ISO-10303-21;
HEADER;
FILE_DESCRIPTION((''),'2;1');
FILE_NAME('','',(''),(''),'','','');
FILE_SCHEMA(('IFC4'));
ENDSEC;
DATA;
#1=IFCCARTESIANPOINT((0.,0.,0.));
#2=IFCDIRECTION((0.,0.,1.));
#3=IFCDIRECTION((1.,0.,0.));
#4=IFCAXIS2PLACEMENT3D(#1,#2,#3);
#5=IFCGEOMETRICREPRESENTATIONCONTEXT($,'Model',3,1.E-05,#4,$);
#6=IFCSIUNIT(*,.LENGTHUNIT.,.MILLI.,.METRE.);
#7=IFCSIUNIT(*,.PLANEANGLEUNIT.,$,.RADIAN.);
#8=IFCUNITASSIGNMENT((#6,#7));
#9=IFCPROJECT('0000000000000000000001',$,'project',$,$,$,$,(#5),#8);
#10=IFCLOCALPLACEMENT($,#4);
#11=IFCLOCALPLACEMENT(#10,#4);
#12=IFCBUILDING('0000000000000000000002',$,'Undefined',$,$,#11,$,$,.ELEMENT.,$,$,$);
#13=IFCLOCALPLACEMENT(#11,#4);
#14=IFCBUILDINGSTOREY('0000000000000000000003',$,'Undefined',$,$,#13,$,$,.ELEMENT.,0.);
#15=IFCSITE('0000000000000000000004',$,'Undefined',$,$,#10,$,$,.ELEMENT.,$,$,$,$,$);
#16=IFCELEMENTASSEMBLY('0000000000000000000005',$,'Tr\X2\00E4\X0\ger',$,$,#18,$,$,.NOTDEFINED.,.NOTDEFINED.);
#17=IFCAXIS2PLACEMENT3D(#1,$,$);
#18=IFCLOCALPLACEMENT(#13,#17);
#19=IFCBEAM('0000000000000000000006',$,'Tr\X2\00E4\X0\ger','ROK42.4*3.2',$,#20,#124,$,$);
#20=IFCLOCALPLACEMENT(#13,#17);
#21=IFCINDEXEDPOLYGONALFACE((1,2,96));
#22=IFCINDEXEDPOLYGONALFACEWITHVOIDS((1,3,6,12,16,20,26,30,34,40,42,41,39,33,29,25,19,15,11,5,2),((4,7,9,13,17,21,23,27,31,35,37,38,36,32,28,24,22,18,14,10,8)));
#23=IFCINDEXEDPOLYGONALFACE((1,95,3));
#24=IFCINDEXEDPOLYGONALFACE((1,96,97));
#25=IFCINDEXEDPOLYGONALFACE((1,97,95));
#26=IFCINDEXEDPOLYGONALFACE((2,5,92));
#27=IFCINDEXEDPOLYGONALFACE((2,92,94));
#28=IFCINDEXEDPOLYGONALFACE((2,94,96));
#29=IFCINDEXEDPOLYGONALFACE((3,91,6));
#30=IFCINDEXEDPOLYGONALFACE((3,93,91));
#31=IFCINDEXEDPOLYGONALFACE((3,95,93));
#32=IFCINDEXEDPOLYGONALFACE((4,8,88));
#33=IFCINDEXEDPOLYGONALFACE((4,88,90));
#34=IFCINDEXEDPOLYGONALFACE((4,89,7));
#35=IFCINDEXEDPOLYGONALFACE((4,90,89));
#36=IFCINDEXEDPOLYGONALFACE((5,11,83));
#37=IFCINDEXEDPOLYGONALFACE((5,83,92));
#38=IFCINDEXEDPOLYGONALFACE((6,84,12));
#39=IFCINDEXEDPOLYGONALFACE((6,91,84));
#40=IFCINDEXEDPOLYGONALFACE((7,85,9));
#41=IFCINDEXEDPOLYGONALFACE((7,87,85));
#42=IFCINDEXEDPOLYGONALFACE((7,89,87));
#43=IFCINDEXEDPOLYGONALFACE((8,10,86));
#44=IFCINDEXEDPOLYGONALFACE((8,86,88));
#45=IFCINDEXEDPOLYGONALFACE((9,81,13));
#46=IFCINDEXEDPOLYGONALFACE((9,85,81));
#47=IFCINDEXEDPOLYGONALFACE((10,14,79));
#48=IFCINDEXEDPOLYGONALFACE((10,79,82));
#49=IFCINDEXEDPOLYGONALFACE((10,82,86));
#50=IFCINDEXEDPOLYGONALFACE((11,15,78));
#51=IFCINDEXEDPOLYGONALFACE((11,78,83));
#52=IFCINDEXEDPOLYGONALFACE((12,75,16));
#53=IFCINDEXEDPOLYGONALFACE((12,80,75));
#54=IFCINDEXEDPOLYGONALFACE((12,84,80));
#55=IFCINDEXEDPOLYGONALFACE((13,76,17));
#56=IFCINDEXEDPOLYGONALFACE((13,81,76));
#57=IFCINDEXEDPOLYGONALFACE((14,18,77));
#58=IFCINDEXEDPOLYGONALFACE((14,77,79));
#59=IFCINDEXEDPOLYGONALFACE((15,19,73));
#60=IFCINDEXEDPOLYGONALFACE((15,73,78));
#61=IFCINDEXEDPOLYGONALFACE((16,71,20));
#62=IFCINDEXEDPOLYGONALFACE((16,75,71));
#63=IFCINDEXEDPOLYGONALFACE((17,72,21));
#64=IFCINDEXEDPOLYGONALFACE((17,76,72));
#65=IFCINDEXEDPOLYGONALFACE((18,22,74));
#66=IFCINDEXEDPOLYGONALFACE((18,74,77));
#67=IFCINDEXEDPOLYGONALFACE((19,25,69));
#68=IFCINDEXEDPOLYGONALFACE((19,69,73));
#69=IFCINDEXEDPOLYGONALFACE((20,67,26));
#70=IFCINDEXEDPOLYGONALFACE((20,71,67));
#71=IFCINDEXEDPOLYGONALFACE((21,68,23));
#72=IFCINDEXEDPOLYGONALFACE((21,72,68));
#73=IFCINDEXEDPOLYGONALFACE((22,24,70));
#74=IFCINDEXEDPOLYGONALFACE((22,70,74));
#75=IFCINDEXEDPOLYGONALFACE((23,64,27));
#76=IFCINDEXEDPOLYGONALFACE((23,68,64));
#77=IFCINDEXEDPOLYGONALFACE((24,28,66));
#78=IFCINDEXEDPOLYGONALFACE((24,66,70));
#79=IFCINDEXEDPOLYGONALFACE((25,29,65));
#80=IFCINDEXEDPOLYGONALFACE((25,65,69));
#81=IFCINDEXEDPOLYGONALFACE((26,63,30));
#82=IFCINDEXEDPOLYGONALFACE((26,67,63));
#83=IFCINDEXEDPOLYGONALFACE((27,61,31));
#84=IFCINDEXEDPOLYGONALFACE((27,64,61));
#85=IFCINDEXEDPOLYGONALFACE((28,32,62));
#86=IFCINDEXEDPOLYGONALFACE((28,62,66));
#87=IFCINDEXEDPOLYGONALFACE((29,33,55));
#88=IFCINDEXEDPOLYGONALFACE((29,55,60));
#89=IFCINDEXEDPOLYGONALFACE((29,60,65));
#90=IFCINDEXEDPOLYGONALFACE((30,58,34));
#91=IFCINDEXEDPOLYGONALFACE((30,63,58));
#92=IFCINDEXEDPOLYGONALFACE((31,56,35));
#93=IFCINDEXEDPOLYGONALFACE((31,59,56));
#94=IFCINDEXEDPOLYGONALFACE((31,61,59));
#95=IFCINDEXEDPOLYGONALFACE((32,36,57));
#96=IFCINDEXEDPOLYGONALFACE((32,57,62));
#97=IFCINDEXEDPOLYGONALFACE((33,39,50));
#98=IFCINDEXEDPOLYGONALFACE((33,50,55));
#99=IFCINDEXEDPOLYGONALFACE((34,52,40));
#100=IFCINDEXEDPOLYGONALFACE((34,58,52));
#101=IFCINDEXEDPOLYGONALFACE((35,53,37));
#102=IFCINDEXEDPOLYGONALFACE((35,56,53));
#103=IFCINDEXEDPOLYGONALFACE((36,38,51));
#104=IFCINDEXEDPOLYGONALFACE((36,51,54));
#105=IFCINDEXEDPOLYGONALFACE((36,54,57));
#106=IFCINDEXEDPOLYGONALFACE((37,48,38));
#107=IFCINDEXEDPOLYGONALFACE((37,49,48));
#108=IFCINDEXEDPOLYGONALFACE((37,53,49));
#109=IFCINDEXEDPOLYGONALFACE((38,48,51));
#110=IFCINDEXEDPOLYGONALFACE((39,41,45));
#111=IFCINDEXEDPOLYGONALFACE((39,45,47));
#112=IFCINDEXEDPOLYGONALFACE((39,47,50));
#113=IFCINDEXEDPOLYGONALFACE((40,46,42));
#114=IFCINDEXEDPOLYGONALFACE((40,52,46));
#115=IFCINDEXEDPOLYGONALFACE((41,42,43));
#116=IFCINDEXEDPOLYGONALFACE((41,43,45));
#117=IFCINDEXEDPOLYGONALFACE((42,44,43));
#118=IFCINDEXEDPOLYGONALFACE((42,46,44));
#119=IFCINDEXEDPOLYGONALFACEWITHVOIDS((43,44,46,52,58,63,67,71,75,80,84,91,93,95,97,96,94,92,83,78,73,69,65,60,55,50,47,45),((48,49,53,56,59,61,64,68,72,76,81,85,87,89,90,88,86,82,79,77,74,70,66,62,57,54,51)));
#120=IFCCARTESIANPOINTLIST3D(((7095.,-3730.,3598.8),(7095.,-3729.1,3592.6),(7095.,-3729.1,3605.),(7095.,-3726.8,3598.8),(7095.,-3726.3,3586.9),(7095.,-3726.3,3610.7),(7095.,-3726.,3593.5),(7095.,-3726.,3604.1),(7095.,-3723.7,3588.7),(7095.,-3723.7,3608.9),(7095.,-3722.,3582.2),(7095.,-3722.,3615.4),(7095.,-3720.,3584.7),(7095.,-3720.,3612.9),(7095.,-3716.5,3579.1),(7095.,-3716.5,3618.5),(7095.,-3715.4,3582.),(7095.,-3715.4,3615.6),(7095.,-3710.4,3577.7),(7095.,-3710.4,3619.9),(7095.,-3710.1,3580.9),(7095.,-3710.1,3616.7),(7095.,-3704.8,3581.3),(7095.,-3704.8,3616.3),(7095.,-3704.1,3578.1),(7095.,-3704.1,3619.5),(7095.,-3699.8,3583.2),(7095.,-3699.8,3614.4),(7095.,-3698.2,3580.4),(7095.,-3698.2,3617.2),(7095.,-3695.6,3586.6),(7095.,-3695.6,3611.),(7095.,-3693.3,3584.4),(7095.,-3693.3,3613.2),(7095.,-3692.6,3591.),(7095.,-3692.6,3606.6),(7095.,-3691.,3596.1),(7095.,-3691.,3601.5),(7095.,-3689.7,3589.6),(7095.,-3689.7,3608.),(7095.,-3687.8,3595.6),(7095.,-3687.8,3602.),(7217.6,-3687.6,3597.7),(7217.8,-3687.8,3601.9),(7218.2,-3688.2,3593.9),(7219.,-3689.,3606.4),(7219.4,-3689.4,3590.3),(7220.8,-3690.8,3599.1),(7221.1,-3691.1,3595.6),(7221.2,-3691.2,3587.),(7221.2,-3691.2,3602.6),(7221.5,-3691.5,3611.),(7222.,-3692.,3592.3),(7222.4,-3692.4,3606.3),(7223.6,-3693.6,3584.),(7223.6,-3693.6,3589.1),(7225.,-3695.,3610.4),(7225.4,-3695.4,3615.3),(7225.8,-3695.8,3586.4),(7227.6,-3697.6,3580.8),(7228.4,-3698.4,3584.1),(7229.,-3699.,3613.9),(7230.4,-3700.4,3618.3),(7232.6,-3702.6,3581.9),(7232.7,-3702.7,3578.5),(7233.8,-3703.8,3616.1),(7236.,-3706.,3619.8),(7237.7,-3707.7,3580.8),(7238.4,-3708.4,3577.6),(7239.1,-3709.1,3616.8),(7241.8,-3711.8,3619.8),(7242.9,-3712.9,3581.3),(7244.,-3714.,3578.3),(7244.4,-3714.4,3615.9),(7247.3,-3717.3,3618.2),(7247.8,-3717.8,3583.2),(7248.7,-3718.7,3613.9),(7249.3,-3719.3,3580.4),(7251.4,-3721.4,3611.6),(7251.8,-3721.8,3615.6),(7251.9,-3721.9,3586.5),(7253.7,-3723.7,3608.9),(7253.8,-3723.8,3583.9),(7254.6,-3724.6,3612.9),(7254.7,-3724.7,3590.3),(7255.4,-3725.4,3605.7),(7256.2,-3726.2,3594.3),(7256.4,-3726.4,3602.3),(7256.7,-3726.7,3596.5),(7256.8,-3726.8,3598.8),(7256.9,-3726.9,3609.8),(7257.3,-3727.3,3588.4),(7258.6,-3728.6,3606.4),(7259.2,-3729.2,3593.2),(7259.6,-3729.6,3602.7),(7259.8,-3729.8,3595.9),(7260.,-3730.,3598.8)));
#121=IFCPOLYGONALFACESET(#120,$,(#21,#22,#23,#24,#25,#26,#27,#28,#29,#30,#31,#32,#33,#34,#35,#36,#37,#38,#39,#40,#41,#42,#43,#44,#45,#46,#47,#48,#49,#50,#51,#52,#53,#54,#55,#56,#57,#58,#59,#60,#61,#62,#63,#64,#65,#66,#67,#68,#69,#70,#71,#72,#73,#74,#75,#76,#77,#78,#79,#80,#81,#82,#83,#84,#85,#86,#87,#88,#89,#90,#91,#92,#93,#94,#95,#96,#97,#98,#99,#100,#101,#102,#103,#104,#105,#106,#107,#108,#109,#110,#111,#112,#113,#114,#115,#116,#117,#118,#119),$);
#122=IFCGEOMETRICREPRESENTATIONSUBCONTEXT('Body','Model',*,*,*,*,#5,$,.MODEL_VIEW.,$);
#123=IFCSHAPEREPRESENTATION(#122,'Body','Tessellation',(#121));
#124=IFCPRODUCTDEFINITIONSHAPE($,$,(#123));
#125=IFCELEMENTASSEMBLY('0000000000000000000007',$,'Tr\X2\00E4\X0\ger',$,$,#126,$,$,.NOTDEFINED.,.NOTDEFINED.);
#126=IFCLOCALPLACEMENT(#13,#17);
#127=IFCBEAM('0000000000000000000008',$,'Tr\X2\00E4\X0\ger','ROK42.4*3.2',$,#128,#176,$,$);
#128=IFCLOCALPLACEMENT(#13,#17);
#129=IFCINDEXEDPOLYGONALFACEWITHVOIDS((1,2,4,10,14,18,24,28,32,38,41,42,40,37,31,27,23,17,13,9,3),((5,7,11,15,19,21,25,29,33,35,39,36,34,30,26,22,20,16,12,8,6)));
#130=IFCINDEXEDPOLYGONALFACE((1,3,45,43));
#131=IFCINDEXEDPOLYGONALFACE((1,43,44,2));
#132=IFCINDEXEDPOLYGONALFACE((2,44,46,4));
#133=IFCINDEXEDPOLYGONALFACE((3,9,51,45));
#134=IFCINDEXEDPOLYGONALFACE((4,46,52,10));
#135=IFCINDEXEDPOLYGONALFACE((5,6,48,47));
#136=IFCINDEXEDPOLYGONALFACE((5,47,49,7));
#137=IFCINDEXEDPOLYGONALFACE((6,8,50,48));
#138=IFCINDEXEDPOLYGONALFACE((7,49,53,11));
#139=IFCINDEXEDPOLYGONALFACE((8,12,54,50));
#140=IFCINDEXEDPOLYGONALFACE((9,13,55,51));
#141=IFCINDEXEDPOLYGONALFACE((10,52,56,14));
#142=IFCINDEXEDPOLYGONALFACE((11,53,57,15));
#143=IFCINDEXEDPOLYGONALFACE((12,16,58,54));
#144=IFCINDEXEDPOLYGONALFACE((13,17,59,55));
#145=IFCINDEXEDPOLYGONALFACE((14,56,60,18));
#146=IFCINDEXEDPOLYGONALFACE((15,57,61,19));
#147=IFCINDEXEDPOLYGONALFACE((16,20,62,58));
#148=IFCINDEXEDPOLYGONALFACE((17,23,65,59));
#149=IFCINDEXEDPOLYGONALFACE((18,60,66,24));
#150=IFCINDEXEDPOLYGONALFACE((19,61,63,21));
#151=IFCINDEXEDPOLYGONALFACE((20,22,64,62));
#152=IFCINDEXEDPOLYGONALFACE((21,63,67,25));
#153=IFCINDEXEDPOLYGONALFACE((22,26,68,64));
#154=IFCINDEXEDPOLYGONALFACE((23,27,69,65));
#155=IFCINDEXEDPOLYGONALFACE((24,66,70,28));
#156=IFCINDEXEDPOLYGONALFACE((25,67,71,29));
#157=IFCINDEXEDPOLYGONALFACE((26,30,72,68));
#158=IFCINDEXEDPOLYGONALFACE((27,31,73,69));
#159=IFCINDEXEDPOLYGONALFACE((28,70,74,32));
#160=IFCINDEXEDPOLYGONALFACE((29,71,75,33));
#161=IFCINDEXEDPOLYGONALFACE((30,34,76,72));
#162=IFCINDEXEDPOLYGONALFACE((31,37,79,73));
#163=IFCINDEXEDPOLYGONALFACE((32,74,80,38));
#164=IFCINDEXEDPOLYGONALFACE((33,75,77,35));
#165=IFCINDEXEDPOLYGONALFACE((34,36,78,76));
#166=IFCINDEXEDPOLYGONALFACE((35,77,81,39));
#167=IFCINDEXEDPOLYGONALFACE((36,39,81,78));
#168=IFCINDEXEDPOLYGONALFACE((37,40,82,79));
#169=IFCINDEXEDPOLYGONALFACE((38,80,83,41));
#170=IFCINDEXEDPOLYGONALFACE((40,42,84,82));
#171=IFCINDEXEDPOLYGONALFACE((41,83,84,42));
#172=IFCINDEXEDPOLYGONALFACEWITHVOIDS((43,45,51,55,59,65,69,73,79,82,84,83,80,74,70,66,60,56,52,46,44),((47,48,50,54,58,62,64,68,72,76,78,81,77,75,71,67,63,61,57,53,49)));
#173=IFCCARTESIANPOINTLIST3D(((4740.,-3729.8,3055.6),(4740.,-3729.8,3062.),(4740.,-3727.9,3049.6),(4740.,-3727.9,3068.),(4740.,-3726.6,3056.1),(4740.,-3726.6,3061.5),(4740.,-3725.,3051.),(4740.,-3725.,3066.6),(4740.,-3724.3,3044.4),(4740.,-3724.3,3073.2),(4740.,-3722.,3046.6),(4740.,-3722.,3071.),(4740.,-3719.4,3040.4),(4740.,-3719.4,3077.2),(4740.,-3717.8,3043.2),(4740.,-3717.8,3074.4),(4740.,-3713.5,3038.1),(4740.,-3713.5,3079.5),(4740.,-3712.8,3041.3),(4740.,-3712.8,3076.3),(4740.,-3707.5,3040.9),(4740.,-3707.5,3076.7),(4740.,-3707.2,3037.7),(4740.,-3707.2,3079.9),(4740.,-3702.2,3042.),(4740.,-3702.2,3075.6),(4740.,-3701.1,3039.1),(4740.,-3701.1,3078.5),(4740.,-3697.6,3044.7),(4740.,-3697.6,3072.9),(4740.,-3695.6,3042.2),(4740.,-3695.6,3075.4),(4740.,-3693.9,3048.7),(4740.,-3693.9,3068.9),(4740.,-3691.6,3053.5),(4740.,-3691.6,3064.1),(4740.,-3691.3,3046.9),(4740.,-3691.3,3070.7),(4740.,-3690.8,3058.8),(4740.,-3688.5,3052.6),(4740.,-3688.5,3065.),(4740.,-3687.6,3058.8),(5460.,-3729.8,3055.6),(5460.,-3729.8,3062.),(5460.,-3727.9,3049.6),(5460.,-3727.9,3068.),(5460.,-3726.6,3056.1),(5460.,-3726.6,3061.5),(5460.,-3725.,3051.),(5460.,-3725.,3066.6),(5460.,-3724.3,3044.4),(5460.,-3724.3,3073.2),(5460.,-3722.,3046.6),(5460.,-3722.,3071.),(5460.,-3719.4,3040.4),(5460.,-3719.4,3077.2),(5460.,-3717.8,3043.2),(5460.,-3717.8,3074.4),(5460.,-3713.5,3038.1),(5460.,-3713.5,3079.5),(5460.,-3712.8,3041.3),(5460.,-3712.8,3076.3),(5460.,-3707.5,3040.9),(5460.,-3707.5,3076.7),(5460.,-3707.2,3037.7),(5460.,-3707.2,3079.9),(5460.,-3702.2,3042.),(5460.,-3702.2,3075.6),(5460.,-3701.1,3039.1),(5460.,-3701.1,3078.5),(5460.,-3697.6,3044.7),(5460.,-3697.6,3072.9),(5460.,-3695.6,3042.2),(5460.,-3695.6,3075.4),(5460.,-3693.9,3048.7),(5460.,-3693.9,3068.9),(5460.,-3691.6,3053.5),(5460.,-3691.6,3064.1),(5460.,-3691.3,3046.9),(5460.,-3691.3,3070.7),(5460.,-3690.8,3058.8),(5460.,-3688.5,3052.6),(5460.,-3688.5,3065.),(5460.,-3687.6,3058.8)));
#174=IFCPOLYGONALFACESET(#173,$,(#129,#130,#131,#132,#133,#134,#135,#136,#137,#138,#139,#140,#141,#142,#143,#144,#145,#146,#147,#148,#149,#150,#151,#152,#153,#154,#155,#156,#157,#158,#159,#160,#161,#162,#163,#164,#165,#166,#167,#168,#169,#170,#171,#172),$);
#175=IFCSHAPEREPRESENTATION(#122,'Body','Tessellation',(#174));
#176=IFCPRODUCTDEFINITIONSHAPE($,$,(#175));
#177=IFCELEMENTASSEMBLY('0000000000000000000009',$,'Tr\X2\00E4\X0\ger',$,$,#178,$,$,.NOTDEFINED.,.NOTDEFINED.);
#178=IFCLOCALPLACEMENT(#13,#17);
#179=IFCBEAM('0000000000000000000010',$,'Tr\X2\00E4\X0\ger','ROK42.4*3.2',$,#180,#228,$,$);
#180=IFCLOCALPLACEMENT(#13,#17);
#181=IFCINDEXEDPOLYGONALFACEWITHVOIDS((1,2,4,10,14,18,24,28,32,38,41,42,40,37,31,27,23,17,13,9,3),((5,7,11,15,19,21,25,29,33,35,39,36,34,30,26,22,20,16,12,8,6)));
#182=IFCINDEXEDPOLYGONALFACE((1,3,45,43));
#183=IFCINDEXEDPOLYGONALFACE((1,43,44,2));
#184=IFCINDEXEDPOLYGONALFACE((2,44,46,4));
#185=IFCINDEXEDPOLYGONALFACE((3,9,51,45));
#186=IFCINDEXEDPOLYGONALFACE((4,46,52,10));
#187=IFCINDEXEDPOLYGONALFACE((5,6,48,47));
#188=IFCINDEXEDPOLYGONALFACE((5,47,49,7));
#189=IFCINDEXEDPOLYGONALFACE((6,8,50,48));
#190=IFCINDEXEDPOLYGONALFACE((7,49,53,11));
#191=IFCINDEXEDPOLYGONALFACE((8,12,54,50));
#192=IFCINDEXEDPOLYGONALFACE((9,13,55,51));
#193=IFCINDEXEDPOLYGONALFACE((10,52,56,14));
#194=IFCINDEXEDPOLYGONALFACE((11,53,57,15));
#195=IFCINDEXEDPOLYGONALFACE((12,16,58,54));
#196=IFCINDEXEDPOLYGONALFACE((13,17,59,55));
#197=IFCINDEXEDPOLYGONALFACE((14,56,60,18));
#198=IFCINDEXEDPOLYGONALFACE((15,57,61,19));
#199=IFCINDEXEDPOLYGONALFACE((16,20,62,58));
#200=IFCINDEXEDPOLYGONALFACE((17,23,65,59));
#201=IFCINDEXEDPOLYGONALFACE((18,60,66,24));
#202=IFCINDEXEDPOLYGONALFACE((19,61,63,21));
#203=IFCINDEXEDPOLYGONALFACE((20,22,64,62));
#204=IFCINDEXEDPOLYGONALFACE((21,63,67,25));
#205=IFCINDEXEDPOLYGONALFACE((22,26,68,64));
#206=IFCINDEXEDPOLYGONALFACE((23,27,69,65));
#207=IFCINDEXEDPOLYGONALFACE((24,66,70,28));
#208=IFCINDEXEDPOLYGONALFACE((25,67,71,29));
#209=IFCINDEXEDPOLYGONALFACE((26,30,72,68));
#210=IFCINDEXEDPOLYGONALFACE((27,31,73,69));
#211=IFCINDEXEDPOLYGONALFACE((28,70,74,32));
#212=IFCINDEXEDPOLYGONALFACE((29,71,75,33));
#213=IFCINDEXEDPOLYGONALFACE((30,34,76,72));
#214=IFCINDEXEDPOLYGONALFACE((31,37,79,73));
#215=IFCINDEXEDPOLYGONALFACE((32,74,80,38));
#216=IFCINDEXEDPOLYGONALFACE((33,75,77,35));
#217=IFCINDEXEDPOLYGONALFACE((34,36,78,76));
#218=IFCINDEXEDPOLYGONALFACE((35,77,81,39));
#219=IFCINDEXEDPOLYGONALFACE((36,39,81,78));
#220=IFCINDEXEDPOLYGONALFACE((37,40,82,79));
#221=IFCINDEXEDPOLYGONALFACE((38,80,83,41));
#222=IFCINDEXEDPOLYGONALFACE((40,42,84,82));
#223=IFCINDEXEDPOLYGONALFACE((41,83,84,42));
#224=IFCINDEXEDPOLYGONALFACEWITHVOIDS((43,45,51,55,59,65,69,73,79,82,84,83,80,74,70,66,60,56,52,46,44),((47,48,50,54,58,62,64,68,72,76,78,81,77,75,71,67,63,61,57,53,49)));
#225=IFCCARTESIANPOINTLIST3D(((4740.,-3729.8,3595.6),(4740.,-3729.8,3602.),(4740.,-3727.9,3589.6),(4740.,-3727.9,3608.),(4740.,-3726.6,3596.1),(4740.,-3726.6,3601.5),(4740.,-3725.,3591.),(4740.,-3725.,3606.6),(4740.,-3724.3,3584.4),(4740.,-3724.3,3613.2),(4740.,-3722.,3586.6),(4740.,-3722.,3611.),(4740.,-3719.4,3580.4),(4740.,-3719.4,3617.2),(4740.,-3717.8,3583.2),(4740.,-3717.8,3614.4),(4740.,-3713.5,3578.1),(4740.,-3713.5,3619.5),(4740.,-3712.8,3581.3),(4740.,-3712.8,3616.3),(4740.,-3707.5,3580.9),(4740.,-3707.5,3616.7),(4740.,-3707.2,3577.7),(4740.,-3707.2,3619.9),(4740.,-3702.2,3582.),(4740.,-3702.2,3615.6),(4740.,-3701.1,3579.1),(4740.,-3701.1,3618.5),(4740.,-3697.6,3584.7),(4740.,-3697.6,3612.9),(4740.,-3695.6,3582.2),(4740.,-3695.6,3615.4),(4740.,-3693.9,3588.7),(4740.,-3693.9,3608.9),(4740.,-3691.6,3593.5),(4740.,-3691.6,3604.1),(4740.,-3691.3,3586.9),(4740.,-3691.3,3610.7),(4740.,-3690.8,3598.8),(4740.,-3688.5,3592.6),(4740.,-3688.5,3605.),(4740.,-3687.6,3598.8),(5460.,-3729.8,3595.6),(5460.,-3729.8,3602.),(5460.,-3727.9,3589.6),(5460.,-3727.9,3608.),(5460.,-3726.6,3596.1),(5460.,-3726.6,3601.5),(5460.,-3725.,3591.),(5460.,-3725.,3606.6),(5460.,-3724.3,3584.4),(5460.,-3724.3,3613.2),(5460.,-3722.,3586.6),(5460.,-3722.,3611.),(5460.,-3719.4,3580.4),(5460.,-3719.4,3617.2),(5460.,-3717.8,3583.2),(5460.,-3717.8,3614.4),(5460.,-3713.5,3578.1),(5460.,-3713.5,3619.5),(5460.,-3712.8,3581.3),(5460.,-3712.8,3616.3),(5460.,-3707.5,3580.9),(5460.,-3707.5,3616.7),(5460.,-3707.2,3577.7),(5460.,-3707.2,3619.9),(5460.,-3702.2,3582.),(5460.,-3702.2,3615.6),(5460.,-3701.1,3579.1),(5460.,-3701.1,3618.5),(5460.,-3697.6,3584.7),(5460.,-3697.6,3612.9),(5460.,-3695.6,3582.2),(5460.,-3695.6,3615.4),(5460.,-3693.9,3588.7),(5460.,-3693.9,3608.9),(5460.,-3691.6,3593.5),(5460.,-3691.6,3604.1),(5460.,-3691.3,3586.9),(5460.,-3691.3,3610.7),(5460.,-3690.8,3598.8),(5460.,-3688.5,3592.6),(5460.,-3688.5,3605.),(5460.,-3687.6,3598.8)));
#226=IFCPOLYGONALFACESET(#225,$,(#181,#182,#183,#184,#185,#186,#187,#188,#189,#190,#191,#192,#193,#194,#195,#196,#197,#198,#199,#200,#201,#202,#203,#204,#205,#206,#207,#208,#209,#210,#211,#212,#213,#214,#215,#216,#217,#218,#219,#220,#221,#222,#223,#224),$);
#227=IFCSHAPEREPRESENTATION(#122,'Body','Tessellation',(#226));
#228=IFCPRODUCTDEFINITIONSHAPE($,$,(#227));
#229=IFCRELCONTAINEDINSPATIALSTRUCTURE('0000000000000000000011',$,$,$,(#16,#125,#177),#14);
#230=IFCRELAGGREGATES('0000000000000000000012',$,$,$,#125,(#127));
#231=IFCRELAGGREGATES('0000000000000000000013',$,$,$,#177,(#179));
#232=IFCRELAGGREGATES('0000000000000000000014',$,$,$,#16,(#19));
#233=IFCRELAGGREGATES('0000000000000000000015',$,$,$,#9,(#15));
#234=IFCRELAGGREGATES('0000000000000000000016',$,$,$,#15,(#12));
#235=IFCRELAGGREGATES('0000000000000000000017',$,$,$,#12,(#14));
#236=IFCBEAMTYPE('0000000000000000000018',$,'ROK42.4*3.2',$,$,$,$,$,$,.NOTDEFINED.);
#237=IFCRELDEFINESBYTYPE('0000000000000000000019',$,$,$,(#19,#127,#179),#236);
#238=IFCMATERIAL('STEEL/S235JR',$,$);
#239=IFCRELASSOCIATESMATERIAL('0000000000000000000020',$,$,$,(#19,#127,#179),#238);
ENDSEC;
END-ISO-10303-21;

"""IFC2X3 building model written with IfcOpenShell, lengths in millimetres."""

from ifc_helpers import new_model, si_unit, frame, origin_with_axes, origin_2d_with_axis, place, context, subcontext, project, spatial, hollow_circle, extrude, clip, halfspace, material, type_object, element, aggregate, save


model = new_model("IFC2X3")

# Units and contexts
model_context = context("Model", 3, precision=1e-05, world=origin_with_axes())
body_context = subcontext(model_context, "Body", "Model", "MODEL_VIEW")
ifc_project = project(units=[si_unit("LENGTHUNIT", "METRE", prefix="MILLI"), si_unit("PLANEANGLEUNIT", "RADIAN")], contexts=[model_context])

# Site, building, storey
site_placement = place(None, origin_with_axes())
site = spatial("IfcSite", under=ifc_project, at=site_placement, Name="Undefined", CompositionType="ELEMENT")
building_placement = place(site_placement, origin_with_axes())
building = spatial("IfcBuilding", under=site, at=building_placement, Name="Undefined", CompositionType="ELEMENT")
storey_placement = place(building_placement, origin_with_axes())
storey = spatial("IfcBuildingStorey", under=building, at=storey_placement, Name="Undefined", CompositionType="ELEMENT", Elevation=0.0)

# Element assembly
ifc_material_1 = material(Name="STEEL/S235JR")
beam_type_1 = type_object("IfcBeamType", Name="ROK42.4*3.2", PredefinedType="NOTDEFINED")
assembly_1_placement = place(storey_placement, origin_with_axes())
assembly_1 = element("IfcElementAssembly", 1, at=assembly_1_placement, inside=storey, Name="Träger", AssemblyPlace="NOTDEFINED", PredefinedType="NOTDEFINED")

# Beam
beam_1_placement = place(assembly_1_placement, frame((7095.0, -3708.8, 3598.8), z_axis=(0.0, 0.0, 1.0), x_axis=(1.0, 0.0, 0.0)))
beam_1 = element("IfcBeam", 2, at=beam_1_placement, type_object=beam_type_1, material=ifc_material_1, Name="Träger", Description="ROK42.4*3.2", context=body_context, shape_type="Clipping", body=[
    clip(extrude(hollow_circle(Radius=21.2, WallThickness=3.2, at=origin_2d_with_axis()), frame((165.2, 0.0, 0.0), z_axis=(-1.0, 0.0, 0.0), x_axis=(0.0, -1.0, 0.0)), (0.0, 0.0, 1.0), 165.2), halfspace(frame((122.6, 21.2, 0.0), z_axis=(-0.707107, -0.707107, 0.0), x_axis=(0.0, 0.0, 1.0)), True)),
])

# Element assemblies, beams
assembly_2_placement = place(storey_placement, origin_with_axes())
assembly_2 = element("IfcElementAssembly", 3, at=assembly_2_placement, inside=storey, Name="Träger", AssemblyPlace="NOTDEFINED", PredefinedType="NOTDEFINED")
beam_2_placement = place(assembly_2_placement, frame((5460.0, -3708.8, 3058.8), z_axis=(0.0, 0.0, 1.0), x_axis=(-1.0, 0.0, 0.0)))
beam_2 = element("IfcBeam", 4, at=beam_2_placement, type_object=beam_type_1, material=ifc_material_1, Name="Träger", Description="ROK42.4*3.2", context=body_context, shape_type="SweptSolid", body=[
    extrude(hollow_circle(Radius=21.2, WallThickness=3.2, at=origin_2d_with_axis()), frame((720.0, 0.0, 0.0), z_axis=(-1.0, 0.0, 0.0), x_axis=(0.0, -1.0, 0.0)), (0.0, 0.0, 1.0), 720.0),
])
aggregate(assembly_2, [beam_2])
assembly_3_placement = place(storey_placement, origin_with_axes())
assembly_3 = element("IfcElementAssembly", 5, at=assembly_3_placement, inside=storey, Name="Träger", AssemblyPlace="NOTDEFINED", PredefinedType="NOTDEFINED")
beam_3_placement = place(assembly_3_placement, frame((5460.0, -3708.8, 3598.8), z_axis=(0.0, 0.0, 1.0), x_axis=(-1.0, 0.0, 0.0)))
beam_3 = element("IfcBeam", 6, at=beam_3_placement, type_object=beam_type_1, material=ifc_material_1, Name="Träger", Description="ROK42.4*3.2", context=body_context, shape_type="SweptSolid", body=[
    extrude(hollow_circle(Radius=21.2, WallThickness=3.2, at=origin_2d_with_axis()), frame((720.0, 0.0, 0.0), z_axis=(-1.0, 0.0, 0.0), x_axis=(0.0, -1.0, 0.0)), (0.0, 0.0, 1.0), 720.0),
])
aggregate(assembly_3, [beam_3])

aggregate(assembly_1, [beam_1])

save(model, "model.ifc")
